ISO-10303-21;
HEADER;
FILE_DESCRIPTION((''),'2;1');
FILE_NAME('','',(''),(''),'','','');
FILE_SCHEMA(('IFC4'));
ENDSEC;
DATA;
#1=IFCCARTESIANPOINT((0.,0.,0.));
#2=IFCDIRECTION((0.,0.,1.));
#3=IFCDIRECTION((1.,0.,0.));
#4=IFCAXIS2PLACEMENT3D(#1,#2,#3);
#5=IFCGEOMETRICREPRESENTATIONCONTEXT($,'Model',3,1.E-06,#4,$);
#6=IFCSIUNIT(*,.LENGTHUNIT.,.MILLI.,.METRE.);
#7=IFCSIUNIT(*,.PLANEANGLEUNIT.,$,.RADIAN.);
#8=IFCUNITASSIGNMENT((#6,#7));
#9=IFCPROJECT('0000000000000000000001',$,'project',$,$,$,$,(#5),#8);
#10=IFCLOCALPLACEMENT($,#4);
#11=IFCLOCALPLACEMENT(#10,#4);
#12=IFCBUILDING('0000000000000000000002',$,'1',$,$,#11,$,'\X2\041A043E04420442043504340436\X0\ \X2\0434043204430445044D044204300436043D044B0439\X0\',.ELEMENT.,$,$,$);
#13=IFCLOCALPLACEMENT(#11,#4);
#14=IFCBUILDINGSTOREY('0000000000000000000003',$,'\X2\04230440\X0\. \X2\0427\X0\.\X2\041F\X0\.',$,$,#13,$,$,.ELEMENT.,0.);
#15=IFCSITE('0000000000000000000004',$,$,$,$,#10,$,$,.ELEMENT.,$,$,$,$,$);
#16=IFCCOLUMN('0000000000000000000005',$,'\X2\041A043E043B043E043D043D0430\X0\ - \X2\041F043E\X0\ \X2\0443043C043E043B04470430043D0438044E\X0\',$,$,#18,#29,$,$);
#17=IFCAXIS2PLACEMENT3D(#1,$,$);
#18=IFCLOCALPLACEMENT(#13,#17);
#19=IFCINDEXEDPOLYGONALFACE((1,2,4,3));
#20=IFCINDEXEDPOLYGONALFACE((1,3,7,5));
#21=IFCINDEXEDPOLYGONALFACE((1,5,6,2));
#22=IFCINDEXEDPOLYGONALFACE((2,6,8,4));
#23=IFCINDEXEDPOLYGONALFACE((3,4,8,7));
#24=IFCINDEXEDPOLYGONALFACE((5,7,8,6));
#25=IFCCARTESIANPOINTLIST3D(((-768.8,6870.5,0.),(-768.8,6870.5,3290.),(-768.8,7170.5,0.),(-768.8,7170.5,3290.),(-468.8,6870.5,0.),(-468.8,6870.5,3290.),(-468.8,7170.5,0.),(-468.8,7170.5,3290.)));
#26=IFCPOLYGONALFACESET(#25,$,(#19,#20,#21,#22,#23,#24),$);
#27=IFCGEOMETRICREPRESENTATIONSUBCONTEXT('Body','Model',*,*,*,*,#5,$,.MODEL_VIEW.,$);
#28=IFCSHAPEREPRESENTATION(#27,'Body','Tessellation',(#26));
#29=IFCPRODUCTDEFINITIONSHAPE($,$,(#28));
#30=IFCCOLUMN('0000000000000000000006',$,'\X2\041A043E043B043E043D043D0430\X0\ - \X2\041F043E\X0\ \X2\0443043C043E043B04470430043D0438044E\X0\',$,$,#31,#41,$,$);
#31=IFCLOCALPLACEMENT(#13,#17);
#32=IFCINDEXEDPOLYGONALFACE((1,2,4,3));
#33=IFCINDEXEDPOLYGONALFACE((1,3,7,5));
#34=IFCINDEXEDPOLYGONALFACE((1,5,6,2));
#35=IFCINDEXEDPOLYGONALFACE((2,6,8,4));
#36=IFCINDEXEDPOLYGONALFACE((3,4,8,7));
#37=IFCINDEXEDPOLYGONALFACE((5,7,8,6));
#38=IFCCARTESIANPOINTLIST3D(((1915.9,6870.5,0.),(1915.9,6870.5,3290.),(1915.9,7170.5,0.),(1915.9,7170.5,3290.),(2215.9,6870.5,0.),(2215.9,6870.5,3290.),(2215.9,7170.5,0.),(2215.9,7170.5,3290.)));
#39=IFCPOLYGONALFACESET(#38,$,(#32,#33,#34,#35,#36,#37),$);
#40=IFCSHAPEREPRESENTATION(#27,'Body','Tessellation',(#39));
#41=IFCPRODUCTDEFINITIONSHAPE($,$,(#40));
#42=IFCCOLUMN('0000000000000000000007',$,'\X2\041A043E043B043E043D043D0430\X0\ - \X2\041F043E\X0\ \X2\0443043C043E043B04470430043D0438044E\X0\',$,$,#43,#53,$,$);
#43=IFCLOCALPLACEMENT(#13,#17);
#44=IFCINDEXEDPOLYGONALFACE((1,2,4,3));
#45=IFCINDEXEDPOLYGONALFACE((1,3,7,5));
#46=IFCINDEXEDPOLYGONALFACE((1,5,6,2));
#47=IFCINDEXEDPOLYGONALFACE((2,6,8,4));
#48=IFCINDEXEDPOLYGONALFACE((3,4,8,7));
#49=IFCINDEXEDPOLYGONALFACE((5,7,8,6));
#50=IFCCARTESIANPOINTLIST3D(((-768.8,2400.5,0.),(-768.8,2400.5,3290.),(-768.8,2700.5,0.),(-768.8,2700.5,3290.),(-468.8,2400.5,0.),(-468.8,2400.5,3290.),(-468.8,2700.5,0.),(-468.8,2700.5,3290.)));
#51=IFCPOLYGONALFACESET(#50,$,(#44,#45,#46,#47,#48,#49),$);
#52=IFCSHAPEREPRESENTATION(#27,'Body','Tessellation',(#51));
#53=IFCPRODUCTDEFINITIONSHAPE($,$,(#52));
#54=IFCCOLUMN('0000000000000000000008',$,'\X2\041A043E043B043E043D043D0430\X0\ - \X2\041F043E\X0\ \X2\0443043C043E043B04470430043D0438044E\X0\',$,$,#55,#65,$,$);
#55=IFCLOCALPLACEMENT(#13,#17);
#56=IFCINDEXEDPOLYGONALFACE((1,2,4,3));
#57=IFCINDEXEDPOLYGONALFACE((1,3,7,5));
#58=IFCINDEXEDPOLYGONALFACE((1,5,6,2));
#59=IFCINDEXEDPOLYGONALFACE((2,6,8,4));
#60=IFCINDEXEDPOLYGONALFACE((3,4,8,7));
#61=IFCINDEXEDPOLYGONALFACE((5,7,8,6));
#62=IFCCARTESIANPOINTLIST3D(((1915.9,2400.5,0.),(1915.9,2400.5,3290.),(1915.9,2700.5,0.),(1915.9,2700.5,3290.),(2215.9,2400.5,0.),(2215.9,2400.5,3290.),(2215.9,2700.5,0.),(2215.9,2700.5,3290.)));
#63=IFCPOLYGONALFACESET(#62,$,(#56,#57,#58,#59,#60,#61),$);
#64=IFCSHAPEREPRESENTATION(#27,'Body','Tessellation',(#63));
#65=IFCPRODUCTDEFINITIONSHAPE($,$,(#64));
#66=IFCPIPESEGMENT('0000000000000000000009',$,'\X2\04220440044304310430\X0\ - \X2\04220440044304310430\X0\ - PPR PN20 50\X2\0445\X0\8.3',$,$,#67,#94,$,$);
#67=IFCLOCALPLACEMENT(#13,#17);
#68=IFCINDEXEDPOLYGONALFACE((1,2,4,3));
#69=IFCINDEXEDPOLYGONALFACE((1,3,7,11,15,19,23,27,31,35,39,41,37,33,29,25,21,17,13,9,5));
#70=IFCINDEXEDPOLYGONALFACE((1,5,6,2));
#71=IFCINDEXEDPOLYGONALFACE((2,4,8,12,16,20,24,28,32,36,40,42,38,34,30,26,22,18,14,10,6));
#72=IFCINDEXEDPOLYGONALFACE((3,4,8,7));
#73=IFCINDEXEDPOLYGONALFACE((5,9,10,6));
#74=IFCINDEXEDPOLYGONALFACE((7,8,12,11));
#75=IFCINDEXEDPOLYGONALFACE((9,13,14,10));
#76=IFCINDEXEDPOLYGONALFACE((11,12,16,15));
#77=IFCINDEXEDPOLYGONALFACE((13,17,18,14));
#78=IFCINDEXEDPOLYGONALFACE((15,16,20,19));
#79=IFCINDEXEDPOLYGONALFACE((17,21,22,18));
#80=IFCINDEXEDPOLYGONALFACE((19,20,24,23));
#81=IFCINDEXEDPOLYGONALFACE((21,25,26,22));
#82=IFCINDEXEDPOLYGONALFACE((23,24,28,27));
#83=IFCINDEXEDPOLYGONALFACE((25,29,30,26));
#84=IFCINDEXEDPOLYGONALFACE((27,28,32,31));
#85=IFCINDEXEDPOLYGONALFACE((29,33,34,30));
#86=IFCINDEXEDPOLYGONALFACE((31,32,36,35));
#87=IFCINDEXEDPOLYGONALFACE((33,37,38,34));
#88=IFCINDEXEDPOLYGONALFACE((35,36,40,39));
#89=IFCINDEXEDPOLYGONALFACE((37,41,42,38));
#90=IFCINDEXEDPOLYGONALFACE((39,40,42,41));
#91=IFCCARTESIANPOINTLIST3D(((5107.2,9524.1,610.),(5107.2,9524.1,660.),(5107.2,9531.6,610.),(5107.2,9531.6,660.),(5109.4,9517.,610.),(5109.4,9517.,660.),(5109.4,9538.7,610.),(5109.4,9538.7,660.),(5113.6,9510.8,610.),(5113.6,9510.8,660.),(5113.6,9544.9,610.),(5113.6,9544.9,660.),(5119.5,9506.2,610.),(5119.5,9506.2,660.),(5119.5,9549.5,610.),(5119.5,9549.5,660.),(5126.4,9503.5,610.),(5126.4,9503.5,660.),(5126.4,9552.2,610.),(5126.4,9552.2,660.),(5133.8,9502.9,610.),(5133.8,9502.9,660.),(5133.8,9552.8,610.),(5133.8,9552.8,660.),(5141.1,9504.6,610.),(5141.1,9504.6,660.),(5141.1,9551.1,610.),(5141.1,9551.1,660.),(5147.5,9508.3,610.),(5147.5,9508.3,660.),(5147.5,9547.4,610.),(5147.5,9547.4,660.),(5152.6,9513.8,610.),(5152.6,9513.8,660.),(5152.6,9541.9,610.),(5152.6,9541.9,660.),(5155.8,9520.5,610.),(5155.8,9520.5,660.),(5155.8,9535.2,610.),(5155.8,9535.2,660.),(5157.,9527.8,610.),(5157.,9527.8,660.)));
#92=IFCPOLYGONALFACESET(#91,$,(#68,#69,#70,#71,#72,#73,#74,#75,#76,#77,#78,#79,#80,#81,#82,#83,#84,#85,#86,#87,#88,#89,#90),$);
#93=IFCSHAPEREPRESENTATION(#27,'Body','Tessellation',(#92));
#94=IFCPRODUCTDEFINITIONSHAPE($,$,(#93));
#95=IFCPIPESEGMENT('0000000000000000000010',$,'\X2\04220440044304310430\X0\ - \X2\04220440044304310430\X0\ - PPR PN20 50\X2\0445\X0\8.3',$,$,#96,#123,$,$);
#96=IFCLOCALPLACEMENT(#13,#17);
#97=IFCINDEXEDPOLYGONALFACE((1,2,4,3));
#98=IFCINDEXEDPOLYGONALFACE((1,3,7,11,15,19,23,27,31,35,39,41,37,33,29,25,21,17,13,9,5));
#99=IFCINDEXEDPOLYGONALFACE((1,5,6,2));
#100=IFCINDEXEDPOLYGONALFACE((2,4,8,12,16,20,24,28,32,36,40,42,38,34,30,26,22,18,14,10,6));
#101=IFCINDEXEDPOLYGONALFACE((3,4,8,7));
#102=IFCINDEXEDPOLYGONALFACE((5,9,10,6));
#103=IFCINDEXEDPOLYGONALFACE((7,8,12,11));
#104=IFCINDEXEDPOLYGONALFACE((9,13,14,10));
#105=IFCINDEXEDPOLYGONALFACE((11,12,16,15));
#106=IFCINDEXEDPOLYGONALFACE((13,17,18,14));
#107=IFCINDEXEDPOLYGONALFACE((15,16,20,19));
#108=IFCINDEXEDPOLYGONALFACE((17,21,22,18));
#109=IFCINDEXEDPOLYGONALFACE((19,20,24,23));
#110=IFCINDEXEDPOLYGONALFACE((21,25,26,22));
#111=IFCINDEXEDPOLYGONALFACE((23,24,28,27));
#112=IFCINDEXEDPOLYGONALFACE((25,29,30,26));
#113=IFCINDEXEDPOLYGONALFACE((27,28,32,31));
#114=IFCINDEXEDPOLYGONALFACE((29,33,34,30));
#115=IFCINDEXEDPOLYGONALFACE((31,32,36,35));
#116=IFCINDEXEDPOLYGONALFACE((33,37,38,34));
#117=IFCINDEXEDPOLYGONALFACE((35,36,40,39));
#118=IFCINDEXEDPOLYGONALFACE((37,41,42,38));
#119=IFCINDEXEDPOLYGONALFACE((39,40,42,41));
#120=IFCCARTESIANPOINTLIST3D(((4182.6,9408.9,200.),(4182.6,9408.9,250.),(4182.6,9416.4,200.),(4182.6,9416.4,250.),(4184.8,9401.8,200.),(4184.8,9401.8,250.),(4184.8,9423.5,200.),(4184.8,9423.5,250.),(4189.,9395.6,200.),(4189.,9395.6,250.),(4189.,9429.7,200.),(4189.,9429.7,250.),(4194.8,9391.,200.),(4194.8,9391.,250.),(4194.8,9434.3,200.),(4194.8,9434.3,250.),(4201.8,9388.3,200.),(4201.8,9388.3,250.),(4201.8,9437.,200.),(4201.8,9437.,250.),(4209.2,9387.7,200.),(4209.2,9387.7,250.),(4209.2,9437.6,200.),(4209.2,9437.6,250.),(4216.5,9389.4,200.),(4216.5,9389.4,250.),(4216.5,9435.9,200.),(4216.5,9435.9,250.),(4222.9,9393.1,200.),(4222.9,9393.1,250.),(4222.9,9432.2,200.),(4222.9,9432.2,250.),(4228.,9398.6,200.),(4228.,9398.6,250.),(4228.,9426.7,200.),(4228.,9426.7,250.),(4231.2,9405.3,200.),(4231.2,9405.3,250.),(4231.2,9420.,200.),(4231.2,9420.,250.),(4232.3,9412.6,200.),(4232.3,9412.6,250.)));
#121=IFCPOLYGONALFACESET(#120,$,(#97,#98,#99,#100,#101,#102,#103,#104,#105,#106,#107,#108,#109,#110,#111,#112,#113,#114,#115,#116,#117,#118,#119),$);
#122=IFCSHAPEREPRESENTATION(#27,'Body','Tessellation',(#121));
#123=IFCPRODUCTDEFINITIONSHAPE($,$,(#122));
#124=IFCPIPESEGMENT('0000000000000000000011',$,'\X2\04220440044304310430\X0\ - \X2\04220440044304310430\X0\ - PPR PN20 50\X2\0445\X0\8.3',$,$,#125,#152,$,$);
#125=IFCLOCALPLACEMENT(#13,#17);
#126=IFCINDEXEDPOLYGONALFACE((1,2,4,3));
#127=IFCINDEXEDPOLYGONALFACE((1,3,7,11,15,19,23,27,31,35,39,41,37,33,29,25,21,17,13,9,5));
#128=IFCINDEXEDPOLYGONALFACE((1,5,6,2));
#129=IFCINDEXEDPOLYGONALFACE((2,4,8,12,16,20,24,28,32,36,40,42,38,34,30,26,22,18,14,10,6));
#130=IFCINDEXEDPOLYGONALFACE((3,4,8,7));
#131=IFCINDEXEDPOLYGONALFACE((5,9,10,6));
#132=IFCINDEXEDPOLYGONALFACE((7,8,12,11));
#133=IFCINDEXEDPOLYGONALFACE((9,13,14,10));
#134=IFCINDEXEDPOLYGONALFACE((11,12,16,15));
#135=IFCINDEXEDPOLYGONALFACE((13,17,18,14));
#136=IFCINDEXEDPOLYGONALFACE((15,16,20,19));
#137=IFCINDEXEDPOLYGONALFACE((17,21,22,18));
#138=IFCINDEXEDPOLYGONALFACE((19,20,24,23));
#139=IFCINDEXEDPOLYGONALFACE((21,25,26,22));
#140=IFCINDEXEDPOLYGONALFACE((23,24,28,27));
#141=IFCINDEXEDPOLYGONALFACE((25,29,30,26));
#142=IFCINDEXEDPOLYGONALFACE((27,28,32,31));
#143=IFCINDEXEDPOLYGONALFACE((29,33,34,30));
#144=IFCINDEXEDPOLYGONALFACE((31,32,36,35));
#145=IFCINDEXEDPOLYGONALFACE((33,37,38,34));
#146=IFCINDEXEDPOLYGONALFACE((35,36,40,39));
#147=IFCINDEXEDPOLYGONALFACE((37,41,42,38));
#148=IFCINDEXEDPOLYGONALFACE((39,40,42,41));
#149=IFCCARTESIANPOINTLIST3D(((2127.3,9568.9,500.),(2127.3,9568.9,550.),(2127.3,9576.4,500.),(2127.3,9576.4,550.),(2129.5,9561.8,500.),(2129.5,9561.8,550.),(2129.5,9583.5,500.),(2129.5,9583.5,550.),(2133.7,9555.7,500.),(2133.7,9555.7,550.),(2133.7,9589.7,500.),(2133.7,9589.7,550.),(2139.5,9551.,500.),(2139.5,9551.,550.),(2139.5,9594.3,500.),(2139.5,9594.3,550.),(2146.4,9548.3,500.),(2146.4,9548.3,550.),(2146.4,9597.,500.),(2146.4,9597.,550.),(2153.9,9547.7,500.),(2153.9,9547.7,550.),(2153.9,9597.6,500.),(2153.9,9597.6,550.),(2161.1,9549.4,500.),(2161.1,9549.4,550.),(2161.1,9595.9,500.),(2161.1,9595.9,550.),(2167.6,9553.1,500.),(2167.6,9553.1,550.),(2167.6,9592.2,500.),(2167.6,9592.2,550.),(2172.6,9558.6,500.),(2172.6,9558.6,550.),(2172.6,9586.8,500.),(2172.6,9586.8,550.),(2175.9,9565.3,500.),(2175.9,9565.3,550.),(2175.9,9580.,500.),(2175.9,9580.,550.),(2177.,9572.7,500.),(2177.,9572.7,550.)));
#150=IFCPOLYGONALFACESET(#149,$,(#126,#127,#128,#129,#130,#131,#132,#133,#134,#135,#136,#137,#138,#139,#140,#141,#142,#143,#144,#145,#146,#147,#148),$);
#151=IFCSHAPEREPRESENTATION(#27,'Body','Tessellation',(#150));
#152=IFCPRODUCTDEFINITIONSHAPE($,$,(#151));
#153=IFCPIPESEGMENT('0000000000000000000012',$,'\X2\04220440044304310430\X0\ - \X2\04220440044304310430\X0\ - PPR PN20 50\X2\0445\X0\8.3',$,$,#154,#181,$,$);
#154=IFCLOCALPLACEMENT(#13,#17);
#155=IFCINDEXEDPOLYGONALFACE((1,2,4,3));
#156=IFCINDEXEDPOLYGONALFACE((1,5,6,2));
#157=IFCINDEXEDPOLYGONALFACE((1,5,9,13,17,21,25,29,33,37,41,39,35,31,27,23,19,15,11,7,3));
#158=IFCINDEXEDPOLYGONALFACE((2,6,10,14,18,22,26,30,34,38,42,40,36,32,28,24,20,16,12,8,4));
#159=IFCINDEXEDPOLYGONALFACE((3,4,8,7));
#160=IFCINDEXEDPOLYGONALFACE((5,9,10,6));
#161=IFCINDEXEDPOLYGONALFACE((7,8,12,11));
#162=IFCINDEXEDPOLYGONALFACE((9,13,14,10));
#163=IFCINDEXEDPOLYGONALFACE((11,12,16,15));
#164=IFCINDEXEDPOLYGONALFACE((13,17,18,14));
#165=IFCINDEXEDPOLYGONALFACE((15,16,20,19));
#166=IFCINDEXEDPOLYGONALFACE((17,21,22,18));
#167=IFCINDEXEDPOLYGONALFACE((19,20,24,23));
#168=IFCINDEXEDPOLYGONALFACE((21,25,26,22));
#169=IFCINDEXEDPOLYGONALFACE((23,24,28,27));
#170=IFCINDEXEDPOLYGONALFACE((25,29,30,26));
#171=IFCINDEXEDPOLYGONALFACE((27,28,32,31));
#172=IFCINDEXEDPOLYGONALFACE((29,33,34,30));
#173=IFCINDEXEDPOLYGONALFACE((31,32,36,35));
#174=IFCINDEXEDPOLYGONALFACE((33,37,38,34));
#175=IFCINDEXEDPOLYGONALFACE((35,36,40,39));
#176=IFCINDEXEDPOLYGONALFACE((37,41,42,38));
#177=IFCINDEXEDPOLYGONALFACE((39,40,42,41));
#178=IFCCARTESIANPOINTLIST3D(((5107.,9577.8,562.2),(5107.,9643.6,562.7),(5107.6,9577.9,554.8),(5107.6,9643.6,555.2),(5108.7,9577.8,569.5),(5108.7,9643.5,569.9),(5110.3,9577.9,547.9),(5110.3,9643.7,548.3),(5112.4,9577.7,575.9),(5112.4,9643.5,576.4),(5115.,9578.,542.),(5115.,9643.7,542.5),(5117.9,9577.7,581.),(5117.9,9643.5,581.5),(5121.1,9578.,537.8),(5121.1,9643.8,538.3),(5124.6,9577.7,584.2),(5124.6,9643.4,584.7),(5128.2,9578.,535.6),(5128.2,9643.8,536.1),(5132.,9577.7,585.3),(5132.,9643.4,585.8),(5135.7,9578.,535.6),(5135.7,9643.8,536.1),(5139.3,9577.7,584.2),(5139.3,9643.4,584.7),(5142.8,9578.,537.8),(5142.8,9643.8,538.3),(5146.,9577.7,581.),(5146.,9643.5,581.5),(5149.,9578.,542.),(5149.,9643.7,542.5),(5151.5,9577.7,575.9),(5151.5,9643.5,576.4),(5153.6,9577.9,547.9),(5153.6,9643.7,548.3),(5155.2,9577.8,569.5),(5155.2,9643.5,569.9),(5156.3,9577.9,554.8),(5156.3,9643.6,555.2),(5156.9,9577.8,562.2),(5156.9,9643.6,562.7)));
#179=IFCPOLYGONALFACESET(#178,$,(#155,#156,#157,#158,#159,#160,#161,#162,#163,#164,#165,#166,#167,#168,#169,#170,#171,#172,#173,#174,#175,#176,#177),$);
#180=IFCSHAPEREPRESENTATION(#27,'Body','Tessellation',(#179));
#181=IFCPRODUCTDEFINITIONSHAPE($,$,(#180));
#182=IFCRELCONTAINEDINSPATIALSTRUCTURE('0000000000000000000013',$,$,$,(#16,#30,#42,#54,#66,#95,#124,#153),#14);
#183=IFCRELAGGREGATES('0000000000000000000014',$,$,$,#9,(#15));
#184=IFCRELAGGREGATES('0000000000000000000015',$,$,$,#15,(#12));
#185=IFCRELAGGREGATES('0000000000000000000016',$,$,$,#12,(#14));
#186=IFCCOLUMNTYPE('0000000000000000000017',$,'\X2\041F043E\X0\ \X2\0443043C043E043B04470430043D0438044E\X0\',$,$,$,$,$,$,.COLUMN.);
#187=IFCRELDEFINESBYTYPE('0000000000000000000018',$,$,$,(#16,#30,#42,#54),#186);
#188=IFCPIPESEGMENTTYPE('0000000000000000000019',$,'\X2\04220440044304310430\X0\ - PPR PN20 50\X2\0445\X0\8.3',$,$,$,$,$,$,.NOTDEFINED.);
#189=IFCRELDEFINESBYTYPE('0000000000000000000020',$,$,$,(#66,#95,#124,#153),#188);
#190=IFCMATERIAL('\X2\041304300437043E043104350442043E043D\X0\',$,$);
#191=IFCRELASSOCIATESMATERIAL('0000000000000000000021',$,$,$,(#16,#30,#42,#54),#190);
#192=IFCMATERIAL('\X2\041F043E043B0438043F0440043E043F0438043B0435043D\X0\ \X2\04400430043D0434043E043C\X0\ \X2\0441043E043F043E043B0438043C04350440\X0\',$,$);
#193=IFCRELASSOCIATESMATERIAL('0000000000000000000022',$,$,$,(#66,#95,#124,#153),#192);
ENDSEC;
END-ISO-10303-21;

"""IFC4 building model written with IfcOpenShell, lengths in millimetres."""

from ifc_helpers import new_model, entity, si_unit, frame, origin_with_axes, place, context, subcontext, project, spatial, line, indexed_curve, outline, extrude, source, transform, mapped, material, type_object, element, save


model = new_model("IFC4")

# Units and contexts
model_context = context("Model", 3, precision=1e-06, world=origin_with_axes())
body_context = subcontext(model_context, "Body", "Model", "MODEL_VIEW")
ifc_project = project(units=[si_unit("LENGTHUNIT", "METRE", prefix="MILLI"), si_unit("PLANEANGLEUNIT", "RADIAN")], contexts=[model_context])

# Site, building, storey
site_placement = place(None, origin_with_axes())
site = spatial("IfcSite", under=ifc_project, at=site_placement, CompositionType="ELEMENT")
building_placement = place(site_placement, origin_with_axes())
building = spatial("IfcBuilding", under=site, at=building_placement, Name="1", LongName="Коттедж двухэтажный", CompositionType="ELEMENT")
storey_placement = place(building_placement, origin_with_axes())
storey = spatial("IfcBuildingStorey", under=building, at=storey_placement, Name="Ур. Ч.П.", CompositionType="ELEMENT", Elevation=0.0)

# Columns
ifc_material_1 = material(Name="Газобетон")
column_type = type_object("IfcColumnType", Name="По умолчанию", PredefinedType="COLUMN")
shared_shape_1 = source(origin_with_axes(), body_context, "Body", "SweptSolid", [
    extrude(outline(indexed_curve([(-150.0, -150.0), (150.0, -150.0), (150.0, 150.0), (-150.0, 150.0)], segments=[line(1, 2), line(2, 3), line(3, 4), line(4, 1)])), origin_with_axes(), (0.0, 0.0, 1.0), 3290.0),
])
for number, where, z_axis, x_axis, name in (
    (1, (-618.8, 7020.5, 0.0), (0.0, 0.0, 1.0), (1.0, 0.0, 0.0), "Колонна - По умолчанию"),
    (2, (2065.9, 7020.5, 0.0), (0.0, 0.0, 1.0), (1.0, 0.0, 0.0), "Колонна - По умолчанию"),
    (3, (-618.8, 2550.5, 0.0), (0.0, 0.0, 1.0), (1.0, 0.0, 0.0), "Колонна - По умолчанию"),
    (4, (2065.9, 2550.5, 0.0), (0.0, 0.0, 1.0), (1.0, 0.0, 0.0), "Колонна - По умолчанию"),
):
    element("IfcColumn", number, at=place(storey_placement, frame(where, z_axis=z_axis, x_axis=x_axis)), inside=storey, type_object=column_type, material=ifc_material_1, Name=name, context=body_context, shape_type="MappedRepresentation", body=[
        mapped(shared_shape_1, transform((0.0, 0.0, 0.0), x_axis=(1.0, 0.0, 0.0), y_axis=(0.0, 1.0, 0.0), z_axis=(0.0, 0.0, 1.0), scale=1.0)),
    ])

# Pipe segments
ifc_material_2 = material(Name="Полипропилен рандом сополимер")
pipe_segment_type_1 = type_object("IfcPipeSegmentType", Name="Труба - PPR PN20 50х8.3", PredefinedType="NOTDEFINED")
shared_shape_2 = source(origin_with_axes(), body_context, "Body", "AdvancedSweptSolid", [
    entity("IfcSweptDiskSolid", entity("IfcIndexedPolyCurve", entity("IfcCartesianPointList3D", [[0.0, 0.0, 0.0], [0.0, 0.0, 50.0]]), [entity("IfcLineIndex", [1, 2])]), 25.0),
])
for number, where, z_axis, x_axis, name in (
    (5, (5132.0, 9527.8, 660.0), (0.0, 0.0, -1.0), (1.0, 0.0, 0.0), "Труба - Труба - PPR PN20 50х8.3"),
    (6, (4207.3, 9412.6, 250.0), (0.0, 0.0, -1.0), (1.0, 0.0, 0.0), "Труба - Труба - PPR PN20 50х8.3"),
    (7, (2152.0, 9572.7, 550.0), (0.0, 0.0, -1.0), (1.0, 0.0, 0.0), "Труба - Труба - PPR PN20 50х8.3"),
):
    element("IfcPipeSegment", number, at=place(storey_placement, frame(where, z_axis=z_axis, x_axis=x_axis)), inside=storey, type_object=pipe_segment_type_1, material=ifc_material_2, Name=name, context=body_context, shape_type="MappedRepresentation", body=[
        mapped(shared_shape_2, transform((0.0, 0.0, 0.0), x_axis=(1.0, 0.0, 0.0), y_axis=(0.0, 1.0, 0.0), z_axis=(0.0, 0.0, 1.0), scale=1.0)),
    ])
shared_shape_3 = source(origin_with_axes(), body_context, "Body", "AdvancedSweptSolid", [
    entity("IfcSweptDiskSolid", entity("IfcIndexedPolyCurve", entity("IfcCartesianPointList3D", [[0.0, 0.0, 0.0], [65.8, 0.0, 0.5]]), [entity("IfcLineIndex", [1, 2])]), 25.0),
])
pipe_segment_1_placement = place(storey_placement, frame((5132.0, 9577.8, 560.3), z_axis=(0.0, 0.0, 1.0), x_axis=(0.0, 1.0, 0.0)))
element("IfcPipeSegment", 8, at=pipe_segment_1_placement, inside=storey, type_object=pipe_segment_type_1, material=ifc_material_2, Name="Труба - Труба - PPR PN20 50х8.3", context=body_context, shape_type="MappedRepresentation", body=[
    mapped(shared_shape_3, transform((0.0, 0.0, 0.0), x_axis=(1.0, 0.0, 0.0), y_axis=(0.0, 1.0, 0.0), z_axis=(0.0, 0.0, 1.0), scale=1.0)),
])

save(model, "model.ifc")
